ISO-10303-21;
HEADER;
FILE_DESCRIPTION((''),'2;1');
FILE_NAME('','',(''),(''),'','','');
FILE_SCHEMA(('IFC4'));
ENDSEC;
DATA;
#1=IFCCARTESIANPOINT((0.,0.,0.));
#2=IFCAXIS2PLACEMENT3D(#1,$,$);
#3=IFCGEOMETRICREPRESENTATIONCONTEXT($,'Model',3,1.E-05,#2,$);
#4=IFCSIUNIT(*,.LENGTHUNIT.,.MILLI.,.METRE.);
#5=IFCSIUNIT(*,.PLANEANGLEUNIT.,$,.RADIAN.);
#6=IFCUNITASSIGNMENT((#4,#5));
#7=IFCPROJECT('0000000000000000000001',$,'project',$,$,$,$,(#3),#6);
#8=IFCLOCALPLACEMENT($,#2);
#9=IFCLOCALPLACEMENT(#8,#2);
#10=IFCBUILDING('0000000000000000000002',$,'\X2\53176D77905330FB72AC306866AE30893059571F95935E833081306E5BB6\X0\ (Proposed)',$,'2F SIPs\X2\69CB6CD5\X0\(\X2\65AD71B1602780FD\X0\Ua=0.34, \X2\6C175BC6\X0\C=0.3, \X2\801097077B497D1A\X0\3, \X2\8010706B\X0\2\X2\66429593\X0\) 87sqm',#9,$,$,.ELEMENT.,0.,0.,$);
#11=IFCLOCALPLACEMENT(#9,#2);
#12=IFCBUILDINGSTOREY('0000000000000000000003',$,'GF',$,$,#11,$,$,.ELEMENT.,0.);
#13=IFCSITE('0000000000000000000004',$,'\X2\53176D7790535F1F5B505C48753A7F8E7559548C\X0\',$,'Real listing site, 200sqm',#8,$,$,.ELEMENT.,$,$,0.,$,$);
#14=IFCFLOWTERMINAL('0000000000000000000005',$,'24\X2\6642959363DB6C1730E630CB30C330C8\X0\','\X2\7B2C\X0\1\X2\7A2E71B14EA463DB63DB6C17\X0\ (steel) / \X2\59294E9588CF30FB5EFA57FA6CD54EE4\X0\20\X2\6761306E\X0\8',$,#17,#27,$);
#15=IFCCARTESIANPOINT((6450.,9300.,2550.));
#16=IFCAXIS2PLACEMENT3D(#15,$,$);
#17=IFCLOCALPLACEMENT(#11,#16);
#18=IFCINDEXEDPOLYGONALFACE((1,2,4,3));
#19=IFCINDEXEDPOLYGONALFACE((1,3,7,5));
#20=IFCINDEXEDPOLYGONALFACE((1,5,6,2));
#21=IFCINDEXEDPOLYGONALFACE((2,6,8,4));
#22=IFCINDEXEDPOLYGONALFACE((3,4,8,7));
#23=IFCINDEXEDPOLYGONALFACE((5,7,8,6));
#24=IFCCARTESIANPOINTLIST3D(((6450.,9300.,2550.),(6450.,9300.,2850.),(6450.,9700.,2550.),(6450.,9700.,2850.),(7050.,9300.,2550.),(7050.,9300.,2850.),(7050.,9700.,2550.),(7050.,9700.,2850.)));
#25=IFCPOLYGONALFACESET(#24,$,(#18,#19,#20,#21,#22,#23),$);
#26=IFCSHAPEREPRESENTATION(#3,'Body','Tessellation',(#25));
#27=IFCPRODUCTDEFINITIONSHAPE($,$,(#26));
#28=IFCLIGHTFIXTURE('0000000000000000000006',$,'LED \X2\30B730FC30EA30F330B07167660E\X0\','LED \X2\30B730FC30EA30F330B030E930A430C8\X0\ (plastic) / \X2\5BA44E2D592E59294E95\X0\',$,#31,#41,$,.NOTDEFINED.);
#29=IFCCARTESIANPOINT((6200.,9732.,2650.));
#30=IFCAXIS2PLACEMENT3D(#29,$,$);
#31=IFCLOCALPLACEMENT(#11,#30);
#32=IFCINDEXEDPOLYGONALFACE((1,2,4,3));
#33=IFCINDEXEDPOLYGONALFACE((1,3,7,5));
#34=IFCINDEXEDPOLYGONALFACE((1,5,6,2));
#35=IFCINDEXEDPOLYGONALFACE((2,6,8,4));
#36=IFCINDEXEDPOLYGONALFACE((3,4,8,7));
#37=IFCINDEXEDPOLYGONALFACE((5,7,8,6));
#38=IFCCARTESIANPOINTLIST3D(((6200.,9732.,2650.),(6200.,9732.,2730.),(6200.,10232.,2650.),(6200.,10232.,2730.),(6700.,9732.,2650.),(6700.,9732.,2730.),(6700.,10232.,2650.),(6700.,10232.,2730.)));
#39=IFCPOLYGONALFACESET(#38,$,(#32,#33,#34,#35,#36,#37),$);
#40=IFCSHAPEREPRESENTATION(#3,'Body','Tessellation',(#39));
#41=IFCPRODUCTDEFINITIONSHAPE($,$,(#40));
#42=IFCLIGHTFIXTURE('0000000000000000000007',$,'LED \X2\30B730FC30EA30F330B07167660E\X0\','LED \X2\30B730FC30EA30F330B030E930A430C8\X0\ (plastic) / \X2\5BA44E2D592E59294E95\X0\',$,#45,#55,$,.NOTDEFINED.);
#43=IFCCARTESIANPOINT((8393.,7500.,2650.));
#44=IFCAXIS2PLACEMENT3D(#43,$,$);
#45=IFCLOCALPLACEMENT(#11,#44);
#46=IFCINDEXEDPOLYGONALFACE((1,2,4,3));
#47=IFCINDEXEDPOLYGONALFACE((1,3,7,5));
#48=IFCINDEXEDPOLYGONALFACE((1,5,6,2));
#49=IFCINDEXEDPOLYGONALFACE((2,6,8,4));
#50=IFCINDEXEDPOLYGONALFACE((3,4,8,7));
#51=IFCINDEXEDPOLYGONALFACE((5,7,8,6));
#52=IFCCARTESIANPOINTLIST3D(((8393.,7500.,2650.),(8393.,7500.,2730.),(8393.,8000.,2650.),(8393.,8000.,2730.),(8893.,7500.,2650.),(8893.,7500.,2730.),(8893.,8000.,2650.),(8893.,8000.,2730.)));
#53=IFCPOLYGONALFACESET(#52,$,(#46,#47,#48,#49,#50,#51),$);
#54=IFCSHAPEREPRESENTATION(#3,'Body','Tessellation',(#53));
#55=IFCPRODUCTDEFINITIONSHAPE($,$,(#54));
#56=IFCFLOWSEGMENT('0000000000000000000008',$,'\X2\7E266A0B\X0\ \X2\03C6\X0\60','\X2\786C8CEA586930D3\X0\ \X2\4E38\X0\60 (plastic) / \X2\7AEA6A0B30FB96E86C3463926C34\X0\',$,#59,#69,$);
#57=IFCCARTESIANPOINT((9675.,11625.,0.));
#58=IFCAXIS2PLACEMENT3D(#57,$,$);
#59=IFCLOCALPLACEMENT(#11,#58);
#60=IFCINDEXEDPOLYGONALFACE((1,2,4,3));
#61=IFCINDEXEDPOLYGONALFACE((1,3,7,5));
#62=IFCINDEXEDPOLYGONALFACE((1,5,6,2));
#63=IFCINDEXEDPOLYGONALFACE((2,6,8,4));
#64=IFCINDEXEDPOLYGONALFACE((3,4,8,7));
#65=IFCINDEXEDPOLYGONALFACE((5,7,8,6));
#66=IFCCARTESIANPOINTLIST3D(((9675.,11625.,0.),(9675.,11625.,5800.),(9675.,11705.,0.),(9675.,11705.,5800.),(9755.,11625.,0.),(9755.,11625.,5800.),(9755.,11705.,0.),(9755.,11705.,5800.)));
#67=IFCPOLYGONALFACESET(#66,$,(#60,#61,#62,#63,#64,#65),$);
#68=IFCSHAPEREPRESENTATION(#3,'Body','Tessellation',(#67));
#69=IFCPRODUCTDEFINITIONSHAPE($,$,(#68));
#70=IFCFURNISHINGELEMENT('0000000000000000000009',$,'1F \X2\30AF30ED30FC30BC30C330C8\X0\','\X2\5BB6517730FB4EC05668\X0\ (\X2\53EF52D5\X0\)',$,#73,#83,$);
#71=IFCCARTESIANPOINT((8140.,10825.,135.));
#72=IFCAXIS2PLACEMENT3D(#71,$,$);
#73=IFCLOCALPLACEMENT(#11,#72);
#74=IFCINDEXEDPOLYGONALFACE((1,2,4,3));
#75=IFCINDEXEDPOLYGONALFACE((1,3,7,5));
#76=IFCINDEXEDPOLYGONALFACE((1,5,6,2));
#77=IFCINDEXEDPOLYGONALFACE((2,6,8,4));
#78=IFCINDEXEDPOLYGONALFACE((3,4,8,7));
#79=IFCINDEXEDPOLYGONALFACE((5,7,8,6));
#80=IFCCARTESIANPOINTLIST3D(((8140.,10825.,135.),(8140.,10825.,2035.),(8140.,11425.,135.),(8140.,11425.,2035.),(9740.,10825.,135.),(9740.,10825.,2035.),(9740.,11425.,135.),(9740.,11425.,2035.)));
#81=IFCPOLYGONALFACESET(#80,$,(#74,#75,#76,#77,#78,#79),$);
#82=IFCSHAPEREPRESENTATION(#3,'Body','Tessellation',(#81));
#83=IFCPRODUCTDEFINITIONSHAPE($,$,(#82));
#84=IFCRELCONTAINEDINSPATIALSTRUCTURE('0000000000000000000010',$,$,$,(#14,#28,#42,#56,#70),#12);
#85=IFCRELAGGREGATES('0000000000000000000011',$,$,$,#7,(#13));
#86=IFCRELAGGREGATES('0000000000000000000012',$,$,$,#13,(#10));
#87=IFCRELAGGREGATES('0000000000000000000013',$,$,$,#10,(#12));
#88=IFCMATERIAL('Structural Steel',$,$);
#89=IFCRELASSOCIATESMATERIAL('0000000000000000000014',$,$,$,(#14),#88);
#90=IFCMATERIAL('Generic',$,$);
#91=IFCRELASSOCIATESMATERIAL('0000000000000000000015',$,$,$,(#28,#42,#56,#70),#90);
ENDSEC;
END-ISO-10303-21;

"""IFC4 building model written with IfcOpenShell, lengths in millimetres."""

from ifc_helpers import new_model, si_unit, frame, frame_2d, origin, place, context, project, spatial, rectangle, extrude, material, element, save


model = new_model("IFC4")

# Units and contexts
model_context = context("Model", 3, precision=1e-05, world=origin())
ifc_project = project(units=[si_unit("LENGTHUNIT", "METRE", prefix="MILLI"), si_unit("PLANEANGLEUNIT", "RADIAN")], contexts=[model_context])

# Site, building, storey
site_placement = place(None, origin())
site = spatial("IfcSite", under=ifc_project, at=site_placement, Name="北海道弟子屈町美留和", ObjectType="Real listing site, 200sqm", CompositionType="ELEMENT", RefElevation=0.0)
building_placement = place(site_placement, origin())
building = spatial("IfcBuilding", under=site, at=building_placement, Name="北海道・犬と暮らす土間広めの家 (Proposed)", ObjectType="2F SIPs構法(断熱性能Ua=0.34, 気密C=0.3, 耐震等級3, 耐火2時間) 87sqm", CompositionType="ELEMENT", ElevationOfRefHeight=0.0, ElevationOfTerrain=0.0)
storey_placement = place(building_placement, origin())
storey = spatial("IfcBuildingStorey", under=building, at=storey_placement, Name="GF", CompositionType="ELEMENT", Elevation=0.0)

# Shared definitions
ifc_material_1 = material(Name="Generic")

# Flow terminal
ifc_material_2 = material(Name="Structural Steel")
flow_terminal_placement = place(storey_placement, frame((6450.0, 9300.0, 2550.0)))
element("IfcFlowTerminal", 1, at=flow_terminal_placement, inside=storey, material=ifc_material_2, Name="24時間換気ユニット", Description="第1種熱交換換気 (steel) / 天井裏・建基法令20条の8", context=model_context, shape_type="SweptSolid", body=[
    extrude(rectangle(XDim=600.0, YDim=400.0, at=frame_2d((300.0, 200.0))), frame((6450.0, 9300.0, 2550.0)), (0.0, 0.0, 1.0), 300.0),
])

# Light fixtures
light_fixture_1_placement = place(storey_placement, frame((6200.0, 9732.0, 2650.0)))
element("IfcLightFixture", 2, at=light_fixture_1_placement, inside=storey, material=ifc_material_1, Name="LED シーリング照明", Description="LED シーリングライト (plastic) / 室中央天井", PredefinedType="NOTDEFINED", context=model_context, shape_type="SweptSolid", body=[
    extrude(rectangle(XDim=500.0, YDim=500.0, at=frame_2d((250.0, 250.0))), frame((6200.0, 9732.0, 2650.0)), (0.0, 0.0, 1.0), 80.0),
])
light_fixture_2_placement = place(storey_placement, frame((8393.0, 7500.0, 2650.0)))
element("IfcLightFixture", 3, at=light_fixture_2_placement, inside=storey, material=ifc_material_1, Name="LED シーリング照明", Description="LED シーリングライト (plastic) / 室中央天井", PredefinedType="NOTDEFINED", context=model_context, shape_type="SweptSolid", body=[
    extrude(rectangle(XDim=500.0, YDim=500.0, at=frame_2d((250.0, 250.0))), frame((8393.0, 7500.0, 2650.0)), (0.0, 0.0, 1.0), 80.0),
])

# Flow segment
flow_segment_placement = place(storey_placement, frame((9675.0, 11625.0, 0.0)))
element("IfcFlowSegment", 4, at=flow_segment_placement, inside=storey, material=ifc_material_1, Name="縦樋 φ60", Description="硬質塩ビ 丸60 (plastic) / 竪樋・雨水排水", context=model_context, shape_type="SweptSolid", body=[
    extrude(rectangle(XDim=80.0, YDim=80.0, at=frame_2d((40.0, 40.0))), frame((9675.0, 11625.0, 0.0)), (0.0, 0.0, 1.0), 5800.0),
])

# Furnishing element
furnishing_placement = place(storey_placement, frame((8140.0, 10825.0, 135.0)))
element("IfcFurnishingElement", 5, at=furnishing_placement, inside=storey, material=ifc_material_1, Name="1F クローゼット", Description="家具・什器 (可動)", context=model_context, shape_type="SweptSolid", body=[
    extrude(rectangle(XDim=1600.0, YDim=600.0, at=frame_2d((800.0, 300.0))), frame((8140.0, 10825.0, 135.0)), (0.0, 0.0, 1.0), 1900.0),
])

save(model, "model.ifc")
